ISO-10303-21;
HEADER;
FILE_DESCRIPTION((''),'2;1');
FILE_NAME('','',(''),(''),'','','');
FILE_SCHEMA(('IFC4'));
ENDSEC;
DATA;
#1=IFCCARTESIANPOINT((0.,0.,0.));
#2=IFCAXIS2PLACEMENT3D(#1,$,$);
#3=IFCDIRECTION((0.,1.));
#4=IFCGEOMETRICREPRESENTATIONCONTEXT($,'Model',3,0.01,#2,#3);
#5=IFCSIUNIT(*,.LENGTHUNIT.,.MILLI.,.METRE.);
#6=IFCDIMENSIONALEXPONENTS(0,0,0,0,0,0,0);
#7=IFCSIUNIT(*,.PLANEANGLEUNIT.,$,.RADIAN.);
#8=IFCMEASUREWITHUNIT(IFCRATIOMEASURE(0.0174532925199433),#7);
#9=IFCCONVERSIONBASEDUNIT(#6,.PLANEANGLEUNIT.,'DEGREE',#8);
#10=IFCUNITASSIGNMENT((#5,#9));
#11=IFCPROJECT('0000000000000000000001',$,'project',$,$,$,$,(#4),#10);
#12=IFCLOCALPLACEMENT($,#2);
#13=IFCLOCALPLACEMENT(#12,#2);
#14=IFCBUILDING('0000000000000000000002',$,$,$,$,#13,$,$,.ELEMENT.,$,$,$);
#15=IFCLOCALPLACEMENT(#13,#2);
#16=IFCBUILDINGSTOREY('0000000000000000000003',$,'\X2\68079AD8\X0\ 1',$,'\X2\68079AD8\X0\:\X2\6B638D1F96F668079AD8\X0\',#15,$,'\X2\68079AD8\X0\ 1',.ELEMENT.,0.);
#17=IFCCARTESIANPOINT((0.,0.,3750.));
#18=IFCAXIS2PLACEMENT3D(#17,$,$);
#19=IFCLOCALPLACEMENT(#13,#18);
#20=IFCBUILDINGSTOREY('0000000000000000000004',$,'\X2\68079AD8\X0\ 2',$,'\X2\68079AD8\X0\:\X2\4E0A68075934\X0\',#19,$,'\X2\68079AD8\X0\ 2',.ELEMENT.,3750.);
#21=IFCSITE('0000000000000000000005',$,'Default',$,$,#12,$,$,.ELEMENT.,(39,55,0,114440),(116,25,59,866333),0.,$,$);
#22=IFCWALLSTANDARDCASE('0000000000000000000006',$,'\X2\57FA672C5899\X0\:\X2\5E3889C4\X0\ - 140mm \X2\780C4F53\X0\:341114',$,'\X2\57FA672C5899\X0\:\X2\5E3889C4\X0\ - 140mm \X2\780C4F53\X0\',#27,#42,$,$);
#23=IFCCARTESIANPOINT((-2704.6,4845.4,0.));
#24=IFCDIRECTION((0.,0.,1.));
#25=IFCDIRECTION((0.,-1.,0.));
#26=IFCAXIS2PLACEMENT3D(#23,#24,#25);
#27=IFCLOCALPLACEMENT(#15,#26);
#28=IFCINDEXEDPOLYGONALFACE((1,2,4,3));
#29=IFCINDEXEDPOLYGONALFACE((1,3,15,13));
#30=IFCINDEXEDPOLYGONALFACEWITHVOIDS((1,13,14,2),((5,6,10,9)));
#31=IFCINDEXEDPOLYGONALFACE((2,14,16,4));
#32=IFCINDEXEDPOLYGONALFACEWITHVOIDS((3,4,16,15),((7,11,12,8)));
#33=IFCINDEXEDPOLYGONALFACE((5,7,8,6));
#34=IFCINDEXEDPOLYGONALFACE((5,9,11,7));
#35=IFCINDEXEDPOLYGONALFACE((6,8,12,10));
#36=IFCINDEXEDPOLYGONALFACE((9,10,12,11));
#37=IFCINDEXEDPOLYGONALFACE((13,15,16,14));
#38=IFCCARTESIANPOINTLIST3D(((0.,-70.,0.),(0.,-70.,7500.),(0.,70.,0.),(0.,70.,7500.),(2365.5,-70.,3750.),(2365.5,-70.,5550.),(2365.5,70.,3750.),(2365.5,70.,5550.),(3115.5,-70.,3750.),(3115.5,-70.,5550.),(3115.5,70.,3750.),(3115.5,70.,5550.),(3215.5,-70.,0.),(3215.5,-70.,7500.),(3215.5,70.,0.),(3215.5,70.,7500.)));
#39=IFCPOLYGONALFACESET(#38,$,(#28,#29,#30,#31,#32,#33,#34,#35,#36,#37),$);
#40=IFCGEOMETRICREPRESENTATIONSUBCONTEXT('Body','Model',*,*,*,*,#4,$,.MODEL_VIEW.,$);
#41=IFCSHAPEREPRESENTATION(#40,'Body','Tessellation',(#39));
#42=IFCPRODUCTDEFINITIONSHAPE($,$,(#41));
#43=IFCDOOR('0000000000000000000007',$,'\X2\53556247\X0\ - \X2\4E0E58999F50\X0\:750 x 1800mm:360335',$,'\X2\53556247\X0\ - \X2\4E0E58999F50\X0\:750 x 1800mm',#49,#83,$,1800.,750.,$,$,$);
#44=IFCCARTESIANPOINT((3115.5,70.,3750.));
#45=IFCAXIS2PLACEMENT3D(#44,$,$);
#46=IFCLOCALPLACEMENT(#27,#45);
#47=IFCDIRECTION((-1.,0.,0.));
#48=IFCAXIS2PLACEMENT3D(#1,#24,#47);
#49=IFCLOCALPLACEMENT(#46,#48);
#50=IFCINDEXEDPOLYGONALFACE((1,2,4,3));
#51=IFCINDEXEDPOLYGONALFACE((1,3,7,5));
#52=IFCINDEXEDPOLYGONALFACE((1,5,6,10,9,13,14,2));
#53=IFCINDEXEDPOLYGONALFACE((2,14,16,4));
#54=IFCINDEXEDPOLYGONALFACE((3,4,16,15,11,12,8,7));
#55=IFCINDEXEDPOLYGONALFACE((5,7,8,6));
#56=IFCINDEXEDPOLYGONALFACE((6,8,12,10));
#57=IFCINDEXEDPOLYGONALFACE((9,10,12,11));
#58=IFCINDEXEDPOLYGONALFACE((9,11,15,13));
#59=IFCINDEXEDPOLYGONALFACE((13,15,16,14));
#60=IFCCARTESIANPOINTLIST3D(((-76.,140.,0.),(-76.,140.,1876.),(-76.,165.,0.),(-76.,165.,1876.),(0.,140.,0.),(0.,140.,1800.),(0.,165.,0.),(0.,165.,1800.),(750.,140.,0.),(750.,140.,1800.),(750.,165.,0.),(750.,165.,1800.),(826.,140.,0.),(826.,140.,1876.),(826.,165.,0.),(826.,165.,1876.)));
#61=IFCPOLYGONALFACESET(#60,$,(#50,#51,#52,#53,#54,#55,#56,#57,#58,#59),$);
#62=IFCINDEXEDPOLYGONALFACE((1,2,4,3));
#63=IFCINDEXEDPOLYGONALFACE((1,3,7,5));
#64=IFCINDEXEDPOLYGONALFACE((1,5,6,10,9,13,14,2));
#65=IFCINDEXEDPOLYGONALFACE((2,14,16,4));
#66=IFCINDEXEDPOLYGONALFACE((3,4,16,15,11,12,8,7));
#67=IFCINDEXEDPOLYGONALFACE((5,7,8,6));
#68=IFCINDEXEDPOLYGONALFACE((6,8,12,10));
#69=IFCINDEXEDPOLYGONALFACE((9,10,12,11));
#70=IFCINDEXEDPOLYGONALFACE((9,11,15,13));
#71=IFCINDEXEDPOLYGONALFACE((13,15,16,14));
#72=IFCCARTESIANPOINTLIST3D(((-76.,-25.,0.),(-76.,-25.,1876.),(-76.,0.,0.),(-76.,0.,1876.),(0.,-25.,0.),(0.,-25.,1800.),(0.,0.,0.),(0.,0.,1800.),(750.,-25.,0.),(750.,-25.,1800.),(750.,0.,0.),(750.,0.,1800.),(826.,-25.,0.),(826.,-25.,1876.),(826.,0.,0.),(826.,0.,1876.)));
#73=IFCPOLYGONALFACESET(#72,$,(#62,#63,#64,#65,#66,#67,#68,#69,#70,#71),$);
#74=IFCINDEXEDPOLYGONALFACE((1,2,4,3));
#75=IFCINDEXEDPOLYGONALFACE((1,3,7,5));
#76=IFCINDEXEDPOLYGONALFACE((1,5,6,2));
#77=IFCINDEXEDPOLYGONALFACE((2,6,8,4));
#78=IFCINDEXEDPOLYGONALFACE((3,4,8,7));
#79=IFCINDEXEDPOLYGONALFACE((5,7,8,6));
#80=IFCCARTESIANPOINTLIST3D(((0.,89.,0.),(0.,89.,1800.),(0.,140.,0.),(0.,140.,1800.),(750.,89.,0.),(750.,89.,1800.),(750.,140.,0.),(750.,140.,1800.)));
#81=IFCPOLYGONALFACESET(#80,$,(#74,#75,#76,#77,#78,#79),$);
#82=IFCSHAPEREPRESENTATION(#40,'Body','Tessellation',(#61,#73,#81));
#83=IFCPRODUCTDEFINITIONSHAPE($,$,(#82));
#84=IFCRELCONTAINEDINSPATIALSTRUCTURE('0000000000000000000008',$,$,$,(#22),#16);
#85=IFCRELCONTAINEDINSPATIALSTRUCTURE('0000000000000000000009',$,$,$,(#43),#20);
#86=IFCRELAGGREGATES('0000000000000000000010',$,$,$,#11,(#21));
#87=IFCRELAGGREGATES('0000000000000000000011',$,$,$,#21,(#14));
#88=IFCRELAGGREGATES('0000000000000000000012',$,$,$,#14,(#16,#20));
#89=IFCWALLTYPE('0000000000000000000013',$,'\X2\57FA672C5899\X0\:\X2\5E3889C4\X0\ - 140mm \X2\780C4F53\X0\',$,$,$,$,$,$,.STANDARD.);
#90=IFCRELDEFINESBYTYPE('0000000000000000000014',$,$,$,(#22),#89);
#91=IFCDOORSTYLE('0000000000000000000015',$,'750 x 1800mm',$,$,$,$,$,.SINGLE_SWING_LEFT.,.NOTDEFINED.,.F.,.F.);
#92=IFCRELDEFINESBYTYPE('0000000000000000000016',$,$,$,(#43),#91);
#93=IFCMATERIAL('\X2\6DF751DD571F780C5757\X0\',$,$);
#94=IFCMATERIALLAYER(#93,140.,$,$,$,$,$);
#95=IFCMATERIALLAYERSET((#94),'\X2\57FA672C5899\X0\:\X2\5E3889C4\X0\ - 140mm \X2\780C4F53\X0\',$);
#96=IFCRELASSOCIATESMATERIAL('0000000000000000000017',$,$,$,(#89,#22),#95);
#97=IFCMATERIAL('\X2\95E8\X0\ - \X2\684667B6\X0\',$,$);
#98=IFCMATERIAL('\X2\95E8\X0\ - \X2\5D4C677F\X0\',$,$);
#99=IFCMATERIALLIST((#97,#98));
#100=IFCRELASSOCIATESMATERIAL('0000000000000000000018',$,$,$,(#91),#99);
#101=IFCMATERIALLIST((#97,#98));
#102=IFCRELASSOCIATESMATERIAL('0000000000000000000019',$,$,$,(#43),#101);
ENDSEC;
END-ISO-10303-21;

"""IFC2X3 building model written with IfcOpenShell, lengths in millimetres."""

from ifc_helpers import new_model, entity, si_unit, converted_unit, direction, frame, frame_2d, origin, place, context, subcontext, project, spatial, polyline, rectangle, outline, extrude, source, transform, mapped, material, material_list, layer, layer_set, layer_usage, type_object, type_shapes, element, fill, save


model = new_model("IFC2X3")

# Units and contexts
model_context = context("Model", 3, precision=0.01, world=origin(), true_north=direction((0.0, 1.0)))
body_context = subcontext(model_context, "Body", "Model", "MODEL_VIEW")
ifc_project = project(units=[si_unit("LENGTHUNIT", "METRE", prefix="MILLI"), converted_unit("PLANEANGLEUNIT", "DEGREE", entity("IfcRatioMeasure", 0.0174532925199433), si_unit("PLANEANGLEUNIT", "RADIAN"), dimensions=[0, 0, 0, 0, 0, 0, 0])], contexts=[model_context])

# Site, building, storey
site_placement = place(None, origin())
site = spatial("IfcSite", under=ifc_project, at=site_placement, Name="Default", CompositionType="ELEMENT", RefLatitude=(39, 55, 0, 114440), RefLongitude=(116, 25, 59, 866333), RefElevation=0.0)
building_placement = place(site_placement, origin())
building = spatial("IfcBuilding", under=site, at=building_placement, CompositionType="ELEMENT")
storey_1_placement = place(building_placement, origin())
storey_1 = spatial("IfcBuildingStorey", under=building, at=storey_1_placement, Name="标高 1", ObjectType="标高:正负零标高", LongName="标高 1", CompositionType="ELEMENT", Elevation=0.0)

# Wall, opening
ifc_material_1 = material(Name="混凝土砌块")
ifc_layer_1 = layer(ifc_material_1, 140.0)
ifc_layer_set_1 = layer_set([ifc_layer_1], Name="基本墙:常规 - 140mm 砌体")
ifc_layer_usage_1 = layer_usage(ifc_layer_set_1, "AXIS2", "NEGATIVE", 70.0)
wall_type = type_object("IfcWallType", Name="基本墙:常规 - 140mm 砌体", PredefinedType="STANDARD", material=ifc_layer_set_1)
wall_1_placement = place(storey_1_placement, frame((-2704.6, 4845.4, 0.0), z_axis=(0.0, 0.0, 1.0), x_axis=(0.0, -1.0, 0.0)))
wall_1 = element("IfcWallStandardCase", 1, at=wall_1_placement, inside=storey_1, type_object=wall_type, material=ifc_layer_usage_1, Name="基本墙:常规 - 140mm 砌体:341114", ObjectType="基本墙:常规 - 140mm 砌体", context=body_context, shape_type="SweptSolid", body=[
    extrude(rectangle(XDim=3215.5, YDim=140.0, at=frame_2d((1607.8, 0.0), x_axis=(-1.0, 0.0))), origin(), (0.0, 0.0, 1.0), 7500.0),
])
opening_1_placement = place(wall_1_placement, frame((3115.5, 70.0, 3750.0)))
opening_1 = element("IfcOpeningElement", 2, at=opening_1_placement, cuts=wall_1, ObjectType="Opening", context=body_context, shape_type="SweptSolid", body=[
    extrude(rectangle(XDim=750.0, YDim=1800.0, at=frame_2d((900.0, 375.0), x_axis=(0.0, -1.0))), frame((0.0, 0.0, 0.0), z_axis=(0.0, -1.0, 0.0), x_axis=(0.0, 0.0, 1.0)), (0.0, 0.0, 1.0), 140.0),
])

# Shared definitions
storey_2_placement = place(building_placement, frame((0.0, 0.0, 3750.0)))
storey_2 = spatial("IfcBuildingStorey", under=building, at=storey_2_placement, Name="标高 2", ObjectType="标高:上标头", LongName="标高 2", CompositionType="ELEMENT", Elevation=3750.0)

# Door
ifc_material_2 = material(Name="门 - 框架")
ifc_material_3 = material(Name="门 - 嵌板")
ifc_material_list_1 = material_list([ifc_material_2, ifc_material_3])
ifc_material_list_2 = material_list([ifc_material_2, ifc_material_3])
door_style_1 = type_object("IfcDoorStyle", Name="750 x 1800mm", ConstructionType="NOTDEFINED", OperationType="SINGLE_SWING_LEFT", ParameterTakesPrecedence=False, Sizeable=False, material=ifc_material_list_2)
shared_shape_1 = source(origin(), body_context, "Body", "SweptSolid", [
    extrude(outline(polyline([(-451.0, -957.0), (451.0, -957.0), (451.0, 919.0), (375.0, 919.0), (375.0, -881.0), (-375.0, -881.0), (-375.0, 919.0), (-451.0, 919.0), (-451.0, -957.0)])), frame((375.0, 165.0, 919.0), z_axis=(0.0, -1.0, 0.0), x_axis=(-1.0, 0.0, 0.0)), (0.0, 0.0, 1.0), 25.0),
    extrude(outline(polyline([(-957.0, -451.0), (919.0, -451.0), (919.0, -375.0), (-881.0, -375.0), (-881.0, 375.0), (919.0, 375.0), (919.0, 451.0), (-957.0, 451.0), (-957.0, -451.0)])), frame((375.0, 0.0, 919.0), z_axis=(0.0, -1.0, 0.0), x_axis=(0.0, 0.0, -1.0)), (0.0, 0.0, 1.0), 25.0),
    extrude(rectangle(XDim=750.0, YDim=51.0, at=frame_2d((0.0, 0.0), x_axis=(1.0, 0.0))), frame((375.0, 114.5, 0.0)), (0.0, 0.0, 1.0), 1800.0),
])
type_shapes(door_style_1, [shared_shape_1])
door_1_placement = place(opening_1_placement, frame((0.0, 0.0, 0.0), z_axis=(0.0, 0.0, 1.0), x_axis=(-1.0, 0.0, 0.0)))
door_1 = element("IfcDoor", 3, at=door_1_placement, inside=storey_2, type_object=door_style_1, material=ifc_material_list_1, Name="单扇 - 与墙齐:750 x 1800mm:360335", ObjectType="单扇 - 与墙齐:750 x 1800mm", OverallHeight=1800.0, OverallWidth=750.0, context=body_context, shape_type="MappedRepresentation", body=[
    mapped(shared_shape_1, transform((0.0, 0.0, 0.0), scale=1.0)),
])
fill(opening_1, door_1)

save(model, "model.ifc")
